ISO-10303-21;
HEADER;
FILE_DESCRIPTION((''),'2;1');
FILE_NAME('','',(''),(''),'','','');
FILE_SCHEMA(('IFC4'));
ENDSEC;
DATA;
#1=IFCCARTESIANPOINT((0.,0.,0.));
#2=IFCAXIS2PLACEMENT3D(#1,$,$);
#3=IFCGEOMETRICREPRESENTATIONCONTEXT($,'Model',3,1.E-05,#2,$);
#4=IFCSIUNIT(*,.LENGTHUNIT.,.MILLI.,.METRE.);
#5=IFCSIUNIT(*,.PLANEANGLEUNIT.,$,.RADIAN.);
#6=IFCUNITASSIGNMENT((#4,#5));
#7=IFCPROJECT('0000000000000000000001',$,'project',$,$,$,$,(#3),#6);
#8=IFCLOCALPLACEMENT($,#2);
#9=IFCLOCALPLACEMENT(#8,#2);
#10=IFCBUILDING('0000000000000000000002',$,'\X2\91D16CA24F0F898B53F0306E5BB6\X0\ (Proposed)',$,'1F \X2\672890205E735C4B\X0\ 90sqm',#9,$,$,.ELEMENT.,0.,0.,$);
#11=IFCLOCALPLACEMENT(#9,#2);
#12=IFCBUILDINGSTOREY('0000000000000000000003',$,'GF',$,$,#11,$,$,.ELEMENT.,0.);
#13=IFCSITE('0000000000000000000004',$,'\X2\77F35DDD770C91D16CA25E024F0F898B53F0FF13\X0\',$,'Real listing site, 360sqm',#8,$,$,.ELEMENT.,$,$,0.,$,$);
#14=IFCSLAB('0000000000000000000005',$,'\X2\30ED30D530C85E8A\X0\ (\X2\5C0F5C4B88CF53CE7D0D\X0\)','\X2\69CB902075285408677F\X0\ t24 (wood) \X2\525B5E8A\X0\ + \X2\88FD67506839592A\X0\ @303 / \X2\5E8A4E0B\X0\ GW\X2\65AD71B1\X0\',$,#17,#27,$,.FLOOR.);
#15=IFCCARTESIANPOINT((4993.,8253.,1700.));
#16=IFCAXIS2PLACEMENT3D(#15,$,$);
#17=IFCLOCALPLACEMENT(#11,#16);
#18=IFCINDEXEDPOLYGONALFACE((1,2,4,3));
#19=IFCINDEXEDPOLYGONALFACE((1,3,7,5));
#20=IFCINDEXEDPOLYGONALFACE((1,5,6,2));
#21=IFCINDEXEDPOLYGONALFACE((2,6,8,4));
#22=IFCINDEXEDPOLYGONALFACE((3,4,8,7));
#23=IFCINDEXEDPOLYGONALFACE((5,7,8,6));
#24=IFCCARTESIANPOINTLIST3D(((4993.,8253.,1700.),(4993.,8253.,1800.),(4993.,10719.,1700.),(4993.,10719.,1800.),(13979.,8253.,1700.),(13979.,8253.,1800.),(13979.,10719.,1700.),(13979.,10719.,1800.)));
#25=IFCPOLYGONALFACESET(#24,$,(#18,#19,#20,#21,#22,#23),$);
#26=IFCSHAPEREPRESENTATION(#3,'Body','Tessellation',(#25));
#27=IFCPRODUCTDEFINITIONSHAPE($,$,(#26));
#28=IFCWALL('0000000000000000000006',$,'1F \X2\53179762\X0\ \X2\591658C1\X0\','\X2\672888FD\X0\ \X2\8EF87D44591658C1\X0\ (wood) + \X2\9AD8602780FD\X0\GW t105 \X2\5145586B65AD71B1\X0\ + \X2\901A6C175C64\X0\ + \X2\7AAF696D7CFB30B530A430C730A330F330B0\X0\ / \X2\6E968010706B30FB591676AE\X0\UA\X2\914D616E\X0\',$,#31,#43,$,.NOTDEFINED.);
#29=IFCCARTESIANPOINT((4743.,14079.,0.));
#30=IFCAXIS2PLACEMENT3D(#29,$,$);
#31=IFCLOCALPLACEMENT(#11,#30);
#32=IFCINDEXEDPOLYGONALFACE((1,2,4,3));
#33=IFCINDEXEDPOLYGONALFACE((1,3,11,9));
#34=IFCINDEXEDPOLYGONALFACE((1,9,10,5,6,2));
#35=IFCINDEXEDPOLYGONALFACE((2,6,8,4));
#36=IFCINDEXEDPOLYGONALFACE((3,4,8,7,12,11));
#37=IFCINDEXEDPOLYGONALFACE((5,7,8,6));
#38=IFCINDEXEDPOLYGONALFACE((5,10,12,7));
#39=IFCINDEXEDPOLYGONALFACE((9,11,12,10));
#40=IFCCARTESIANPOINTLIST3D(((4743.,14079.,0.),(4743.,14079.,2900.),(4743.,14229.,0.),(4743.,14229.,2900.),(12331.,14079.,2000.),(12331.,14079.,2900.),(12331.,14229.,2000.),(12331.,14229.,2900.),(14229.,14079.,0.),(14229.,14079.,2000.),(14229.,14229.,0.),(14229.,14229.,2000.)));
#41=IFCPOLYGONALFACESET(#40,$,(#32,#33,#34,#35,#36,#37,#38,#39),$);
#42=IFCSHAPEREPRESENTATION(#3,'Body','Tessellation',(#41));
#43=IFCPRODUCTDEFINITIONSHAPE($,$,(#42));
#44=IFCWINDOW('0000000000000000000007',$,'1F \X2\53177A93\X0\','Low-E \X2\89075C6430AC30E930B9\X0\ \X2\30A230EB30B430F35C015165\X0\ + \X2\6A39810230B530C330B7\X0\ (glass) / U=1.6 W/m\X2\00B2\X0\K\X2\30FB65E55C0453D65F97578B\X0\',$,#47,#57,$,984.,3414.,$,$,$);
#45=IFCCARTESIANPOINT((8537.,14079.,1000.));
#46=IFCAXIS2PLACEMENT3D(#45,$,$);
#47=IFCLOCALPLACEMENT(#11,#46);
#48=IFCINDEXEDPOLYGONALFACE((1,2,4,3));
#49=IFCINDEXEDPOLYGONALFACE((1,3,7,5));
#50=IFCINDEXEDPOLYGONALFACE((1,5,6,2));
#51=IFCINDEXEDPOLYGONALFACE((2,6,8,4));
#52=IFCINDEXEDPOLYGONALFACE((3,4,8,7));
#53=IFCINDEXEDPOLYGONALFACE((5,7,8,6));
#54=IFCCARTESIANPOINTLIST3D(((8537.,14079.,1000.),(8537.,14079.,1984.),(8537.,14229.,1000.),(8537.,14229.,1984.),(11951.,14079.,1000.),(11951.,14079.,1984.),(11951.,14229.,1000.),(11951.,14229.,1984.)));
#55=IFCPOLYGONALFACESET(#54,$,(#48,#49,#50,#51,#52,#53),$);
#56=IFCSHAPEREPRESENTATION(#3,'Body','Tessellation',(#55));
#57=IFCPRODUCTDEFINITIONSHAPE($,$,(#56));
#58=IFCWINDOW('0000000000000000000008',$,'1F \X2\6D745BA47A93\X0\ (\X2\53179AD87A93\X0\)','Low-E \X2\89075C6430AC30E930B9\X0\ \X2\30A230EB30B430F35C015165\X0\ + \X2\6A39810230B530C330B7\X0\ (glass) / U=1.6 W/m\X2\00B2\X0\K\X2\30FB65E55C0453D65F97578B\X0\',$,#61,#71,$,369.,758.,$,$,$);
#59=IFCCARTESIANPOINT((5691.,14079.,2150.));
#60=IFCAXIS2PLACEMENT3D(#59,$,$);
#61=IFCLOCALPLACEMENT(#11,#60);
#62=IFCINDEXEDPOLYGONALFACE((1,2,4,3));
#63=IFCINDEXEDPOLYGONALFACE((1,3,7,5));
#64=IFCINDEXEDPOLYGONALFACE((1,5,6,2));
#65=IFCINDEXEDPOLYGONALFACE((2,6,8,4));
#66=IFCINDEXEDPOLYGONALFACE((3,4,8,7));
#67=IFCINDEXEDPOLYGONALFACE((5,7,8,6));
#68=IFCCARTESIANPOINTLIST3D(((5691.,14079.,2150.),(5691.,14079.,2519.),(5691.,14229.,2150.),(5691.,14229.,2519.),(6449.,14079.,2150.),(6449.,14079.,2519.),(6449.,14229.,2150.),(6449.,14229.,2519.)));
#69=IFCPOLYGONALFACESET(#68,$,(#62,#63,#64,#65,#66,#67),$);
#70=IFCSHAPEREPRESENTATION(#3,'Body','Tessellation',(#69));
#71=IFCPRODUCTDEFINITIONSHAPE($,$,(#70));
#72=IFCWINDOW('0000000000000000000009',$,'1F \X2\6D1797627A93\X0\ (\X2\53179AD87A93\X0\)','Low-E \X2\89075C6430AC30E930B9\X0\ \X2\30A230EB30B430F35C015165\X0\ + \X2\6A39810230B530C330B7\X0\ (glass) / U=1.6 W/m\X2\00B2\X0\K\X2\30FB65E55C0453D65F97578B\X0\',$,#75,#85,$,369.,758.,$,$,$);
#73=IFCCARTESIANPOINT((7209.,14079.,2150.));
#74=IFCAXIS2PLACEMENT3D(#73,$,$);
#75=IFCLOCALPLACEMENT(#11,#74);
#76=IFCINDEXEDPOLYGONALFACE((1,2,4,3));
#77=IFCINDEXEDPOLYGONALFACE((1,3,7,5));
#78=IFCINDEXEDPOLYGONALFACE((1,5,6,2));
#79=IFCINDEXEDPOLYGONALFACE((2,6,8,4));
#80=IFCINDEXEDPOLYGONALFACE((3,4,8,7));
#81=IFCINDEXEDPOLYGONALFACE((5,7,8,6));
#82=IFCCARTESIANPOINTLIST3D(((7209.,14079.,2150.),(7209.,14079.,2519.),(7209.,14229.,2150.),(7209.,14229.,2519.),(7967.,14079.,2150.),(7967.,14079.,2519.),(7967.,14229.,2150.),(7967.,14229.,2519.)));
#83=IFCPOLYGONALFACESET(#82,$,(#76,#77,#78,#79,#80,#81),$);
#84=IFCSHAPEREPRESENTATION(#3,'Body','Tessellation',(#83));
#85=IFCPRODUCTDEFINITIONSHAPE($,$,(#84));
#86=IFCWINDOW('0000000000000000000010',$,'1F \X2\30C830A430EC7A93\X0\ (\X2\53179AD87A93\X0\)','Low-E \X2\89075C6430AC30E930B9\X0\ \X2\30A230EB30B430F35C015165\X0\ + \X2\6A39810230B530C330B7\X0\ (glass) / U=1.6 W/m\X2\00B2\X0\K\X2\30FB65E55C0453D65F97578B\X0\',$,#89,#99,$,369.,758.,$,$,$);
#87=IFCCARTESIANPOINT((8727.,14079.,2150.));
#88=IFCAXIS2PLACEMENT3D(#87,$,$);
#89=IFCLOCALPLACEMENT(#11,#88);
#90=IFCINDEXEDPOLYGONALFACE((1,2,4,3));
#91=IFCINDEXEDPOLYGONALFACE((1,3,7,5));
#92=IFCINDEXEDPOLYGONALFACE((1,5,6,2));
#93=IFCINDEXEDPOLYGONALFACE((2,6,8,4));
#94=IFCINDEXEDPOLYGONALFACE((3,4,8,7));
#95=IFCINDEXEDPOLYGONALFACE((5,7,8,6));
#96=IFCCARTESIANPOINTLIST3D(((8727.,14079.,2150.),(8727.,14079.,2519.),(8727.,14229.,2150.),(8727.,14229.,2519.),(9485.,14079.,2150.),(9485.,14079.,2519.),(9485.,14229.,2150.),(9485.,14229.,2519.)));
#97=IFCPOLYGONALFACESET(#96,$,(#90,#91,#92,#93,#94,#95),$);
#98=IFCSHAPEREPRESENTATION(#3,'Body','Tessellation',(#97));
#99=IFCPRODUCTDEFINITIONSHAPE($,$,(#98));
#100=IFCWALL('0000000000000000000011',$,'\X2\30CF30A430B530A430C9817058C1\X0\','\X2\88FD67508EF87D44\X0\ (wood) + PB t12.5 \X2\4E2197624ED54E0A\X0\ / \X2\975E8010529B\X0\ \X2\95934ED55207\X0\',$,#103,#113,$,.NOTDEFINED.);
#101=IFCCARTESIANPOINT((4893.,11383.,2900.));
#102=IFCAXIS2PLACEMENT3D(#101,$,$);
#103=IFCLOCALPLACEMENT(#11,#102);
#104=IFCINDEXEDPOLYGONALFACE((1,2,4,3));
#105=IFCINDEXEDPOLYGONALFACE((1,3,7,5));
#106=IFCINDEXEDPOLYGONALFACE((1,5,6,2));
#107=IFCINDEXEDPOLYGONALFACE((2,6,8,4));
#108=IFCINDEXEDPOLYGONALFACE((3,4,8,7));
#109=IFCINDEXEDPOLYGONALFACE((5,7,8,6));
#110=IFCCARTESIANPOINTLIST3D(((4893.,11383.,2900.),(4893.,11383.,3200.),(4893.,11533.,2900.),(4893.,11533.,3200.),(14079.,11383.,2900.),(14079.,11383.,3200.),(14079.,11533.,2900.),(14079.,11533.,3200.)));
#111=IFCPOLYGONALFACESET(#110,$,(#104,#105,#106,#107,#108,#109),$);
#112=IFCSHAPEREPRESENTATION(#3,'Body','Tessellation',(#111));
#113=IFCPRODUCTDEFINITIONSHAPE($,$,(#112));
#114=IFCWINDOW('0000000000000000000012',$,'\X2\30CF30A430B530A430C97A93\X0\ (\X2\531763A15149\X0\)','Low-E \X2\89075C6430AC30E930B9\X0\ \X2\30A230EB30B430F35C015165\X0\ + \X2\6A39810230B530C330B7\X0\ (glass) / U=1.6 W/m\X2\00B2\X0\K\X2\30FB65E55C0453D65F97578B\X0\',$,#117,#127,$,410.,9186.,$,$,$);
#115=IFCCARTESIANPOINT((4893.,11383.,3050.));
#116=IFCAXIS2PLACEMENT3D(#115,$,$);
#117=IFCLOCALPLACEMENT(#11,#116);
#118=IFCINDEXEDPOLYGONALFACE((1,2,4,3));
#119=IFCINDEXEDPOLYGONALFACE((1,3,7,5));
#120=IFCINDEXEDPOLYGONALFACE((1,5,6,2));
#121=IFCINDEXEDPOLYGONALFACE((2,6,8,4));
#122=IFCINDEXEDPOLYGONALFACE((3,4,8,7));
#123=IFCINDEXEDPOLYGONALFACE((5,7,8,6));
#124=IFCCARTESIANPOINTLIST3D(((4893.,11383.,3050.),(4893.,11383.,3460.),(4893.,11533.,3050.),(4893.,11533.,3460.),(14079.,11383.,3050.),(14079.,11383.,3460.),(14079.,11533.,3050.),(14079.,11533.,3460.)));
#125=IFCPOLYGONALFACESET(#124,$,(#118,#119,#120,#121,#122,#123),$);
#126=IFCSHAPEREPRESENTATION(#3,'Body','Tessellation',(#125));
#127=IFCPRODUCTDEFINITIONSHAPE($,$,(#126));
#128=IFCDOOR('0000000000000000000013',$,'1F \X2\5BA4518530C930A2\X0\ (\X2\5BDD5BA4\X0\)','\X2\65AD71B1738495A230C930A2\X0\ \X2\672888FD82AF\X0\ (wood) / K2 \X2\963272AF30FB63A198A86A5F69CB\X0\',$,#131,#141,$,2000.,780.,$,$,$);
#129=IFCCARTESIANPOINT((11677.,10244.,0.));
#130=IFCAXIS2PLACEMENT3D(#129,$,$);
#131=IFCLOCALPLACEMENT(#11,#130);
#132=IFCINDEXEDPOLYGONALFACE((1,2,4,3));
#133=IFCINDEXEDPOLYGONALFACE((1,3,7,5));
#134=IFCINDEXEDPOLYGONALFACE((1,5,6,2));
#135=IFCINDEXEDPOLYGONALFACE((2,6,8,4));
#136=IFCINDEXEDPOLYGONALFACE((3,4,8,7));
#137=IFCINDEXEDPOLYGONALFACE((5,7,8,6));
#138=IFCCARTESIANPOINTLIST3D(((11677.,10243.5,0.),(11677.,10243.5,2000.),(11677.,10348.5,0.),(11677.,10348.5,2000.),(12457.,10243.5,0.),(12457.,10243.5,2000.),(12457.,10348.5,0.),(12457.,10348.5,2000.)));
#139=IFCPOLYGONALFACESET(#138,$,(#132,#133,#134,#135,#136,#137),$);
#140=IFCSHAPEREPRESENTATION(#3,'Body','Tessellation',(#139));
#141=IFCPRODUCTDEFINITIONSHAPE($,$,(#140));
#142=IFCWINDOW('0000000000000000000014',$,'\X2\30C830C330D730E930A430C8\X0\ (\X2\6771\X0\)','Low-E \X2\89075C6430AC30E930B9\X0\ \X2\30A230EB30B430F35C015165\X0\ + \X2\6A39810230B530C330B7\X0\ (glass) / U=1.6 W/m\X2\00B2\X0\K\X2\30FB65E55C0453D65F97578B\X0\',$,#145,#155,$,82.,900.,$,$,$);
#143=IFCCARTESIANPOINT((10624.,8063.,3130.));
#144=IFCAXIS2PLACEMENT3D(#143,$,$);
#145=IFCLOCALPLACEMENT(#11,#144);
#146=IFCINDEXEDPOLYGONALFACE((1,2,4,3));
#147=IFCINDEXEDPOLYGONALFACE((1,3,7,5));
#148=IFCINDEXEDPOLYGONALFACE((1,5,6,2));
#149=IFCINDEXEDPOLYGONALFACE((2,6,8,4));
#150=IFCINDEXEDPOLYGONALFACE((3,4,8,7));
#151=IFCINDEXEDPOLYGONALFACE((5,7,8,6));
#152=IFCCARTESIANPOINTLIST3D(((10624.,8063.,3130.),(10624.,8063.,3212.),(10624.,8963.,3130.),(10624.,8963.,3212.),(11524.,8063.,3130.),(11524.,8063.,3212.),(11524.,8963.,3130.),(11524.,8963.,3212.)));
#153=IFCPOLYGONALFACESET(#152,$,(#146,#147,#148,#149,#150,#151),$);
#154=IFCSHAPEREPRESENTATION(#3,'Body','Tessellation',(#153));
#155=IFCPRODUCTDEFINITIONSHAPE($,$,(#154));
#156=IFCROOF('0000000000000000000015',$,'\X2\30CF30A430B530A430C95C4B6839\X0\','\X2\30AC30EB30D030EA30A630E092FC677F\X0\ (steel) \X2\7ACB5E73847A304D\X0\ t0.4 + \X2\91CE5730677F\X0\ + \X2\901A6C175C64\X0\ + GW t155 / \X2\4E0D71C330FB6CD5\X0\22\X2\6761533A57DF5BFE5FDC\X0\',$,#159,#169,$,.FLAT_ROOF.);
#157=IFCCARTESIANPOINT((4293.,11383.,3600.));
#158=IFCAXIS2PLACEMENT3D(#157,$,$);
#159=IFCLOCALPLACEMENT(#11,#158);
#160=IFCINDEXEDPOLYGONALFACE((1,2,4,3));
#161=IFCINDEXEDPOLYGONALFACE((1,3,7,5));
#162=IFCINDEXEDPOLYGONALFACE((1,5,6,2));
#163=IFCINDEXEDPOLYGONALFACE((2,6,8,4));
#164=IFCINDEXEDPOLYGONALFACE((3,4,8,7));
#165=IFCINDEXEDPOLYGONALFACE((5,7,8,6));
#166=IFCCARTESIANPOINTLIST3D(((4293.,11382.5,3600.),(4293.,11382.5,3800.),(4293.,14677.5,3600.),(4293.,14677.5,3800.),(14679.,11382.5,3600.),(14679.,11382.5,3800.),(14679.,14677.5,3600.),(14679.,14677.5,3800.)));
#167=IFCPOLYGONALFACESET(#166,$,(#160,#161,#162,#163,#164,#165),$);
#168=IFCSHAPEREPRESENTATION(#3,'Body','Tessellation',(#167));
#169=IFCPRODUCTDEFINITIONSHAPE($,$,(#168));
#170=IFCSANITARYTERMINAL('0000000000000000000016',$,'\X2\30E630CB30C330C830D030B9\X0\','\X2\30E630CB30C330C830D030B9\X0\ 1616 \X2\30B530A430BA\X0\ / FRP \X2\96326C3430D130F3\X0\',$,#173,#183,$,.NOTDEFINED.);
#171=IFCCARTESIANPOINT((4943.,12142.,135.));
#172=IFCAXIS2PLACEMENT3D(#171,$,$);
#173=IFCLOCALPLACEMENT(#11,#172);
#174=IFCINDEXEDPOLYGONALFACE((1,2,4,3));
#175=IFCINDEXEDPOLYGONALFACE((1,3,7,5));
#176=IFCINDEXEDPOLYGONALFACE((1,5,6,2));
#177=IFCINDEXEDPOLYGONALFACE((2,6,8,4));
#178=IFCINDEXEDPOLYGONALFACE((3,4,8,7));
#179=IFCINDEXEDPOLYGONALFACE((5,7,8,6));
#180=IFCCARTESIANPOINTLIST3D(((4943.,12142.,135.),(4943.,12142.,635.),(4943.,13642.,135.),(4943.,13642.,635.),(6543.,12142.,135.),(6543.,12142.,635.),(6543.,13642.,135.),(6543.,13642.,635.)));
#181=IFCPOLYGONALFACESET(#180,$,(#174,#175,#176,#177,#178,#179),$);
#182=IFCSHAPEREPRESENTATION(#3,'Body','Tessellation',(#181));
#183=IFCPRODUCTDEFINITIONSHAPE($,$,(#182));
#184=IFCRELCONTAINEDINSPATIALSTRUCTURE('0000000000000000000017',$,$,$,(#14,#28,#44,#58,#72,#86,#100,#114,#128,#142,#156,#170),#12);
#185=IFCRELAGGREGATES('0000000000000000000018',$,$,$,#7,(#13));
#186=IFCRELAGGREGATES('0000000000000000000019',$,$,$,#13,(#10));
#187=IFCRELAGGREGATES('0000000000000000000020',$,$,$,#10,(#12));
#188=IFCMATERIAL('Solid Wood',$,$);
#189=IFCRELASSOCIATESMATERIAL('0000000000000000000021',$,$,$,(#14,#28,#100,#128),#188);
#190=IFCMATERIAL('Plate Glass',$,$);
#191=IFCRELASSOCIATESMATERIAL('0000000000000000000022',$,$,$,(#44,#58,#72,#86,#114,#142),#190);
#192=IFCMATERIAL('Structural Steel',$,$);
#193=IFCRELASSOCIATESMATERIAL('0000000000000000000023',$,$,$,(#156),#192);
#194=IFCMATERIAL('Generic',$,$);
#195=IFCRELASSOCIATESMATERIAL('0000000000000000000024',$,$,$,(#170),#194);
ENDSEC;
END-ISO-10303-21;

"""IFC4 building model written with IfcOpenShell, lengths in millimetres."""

from ifc_helpers import new_model, si_unit, frame, frame_2d, origin, place, context, project, spatial, rectangle, extrude, material, element, fill, save


model = new_model("IFC4")

# Units and contexts
model_context = context("Model", 3, precision=1e-05, world=origin())
ifc_project = project(units=[si_unit("LENGTHUNIT", "METRE", prefix="MILLI"), si_unit("PLANEANGLEUNIT", "RADIAN")], contexts=[model_context])

# Site, building, storey
site_placement = place(None, origin())
site = spatial("IfcSite", under=ifc_project, at=site_placement, Name="石川県金沢市伏見台３", ObjectType="Real listing site, 360sqm", CompositionType="ELEMENT", RefElevation=0.0)
building_placement = place(site_placement, origin())
building = spatial("IfcBuilding", under=site, at=building_placement, Name="金沢伏見台の家 (Proposed)", ObjectType="1F 木造平屋 90sqm", CompositionType="ELEMENT", ElevationOfRefHeight=0.0, ElevationOfTerrain=0.0)
storey_placement = place(building_placement, origin())
storey = spatial("IfcBuildingStorey", under=building, at=storey_placement, Name="GF", CompositionType="ELEMENT", Elevation=0.0)

# Slab
ifc_material_1 = material(Name="Solid Wood")
slab_placement = place(storey_placement, frame((4993.0, 8253.0, 1700.0)))
element("IfcSlab", 1, at=slab_placement, inside=storey, material=ifc_material_1, Name="ロフト床 (小屋裏収納)", Description="構造用合板 t24 (wood) 剛床 + 製材根太 @303 / 床下 GW断熱", PredefinedType="FLOOR", context=model_context, shape_type="SweptSolid", body=[
    extrude(rectangle(XDim=8986.0, YDim=2466.0, at=frame_2d((4493.0, 1233.0))), frame((4993.0, 8253.0, 1700.0)), (0.0, 0.0, 1.0), 100.0),
])

# Wall, openings, windows
wall_1_placement = place(storey_placement, frame((4743.0, 14079.0, 0.0)))
wall_1 = element("IfcWall", 2, at=wall_1_placement, inside=storey, material=ifc_material_1, Name="1F 北面 外壁", Description="木製 軸組外壁 (wood) + 高性能GW t105 充填断熱 + 通気層 + 窯業系サイディング / 準耐火・外皮UA配慮", PredefinedType="NOTDEFINED", context=model_context, shape_type="SweptSolid", body=[
    extrude(rectangle(XDim=9486.0, YDim=150.0, at=frame_2d((4743.0, 75.0))), frame((4743.0, 14079.0, 0.0)), (0.0, 0.0, 1.0), 2900.0),
])
opening_1_placement = place(storey_placement, frame((8537.0, 14079.0, 1000.0)))
opening_1 = element("IfcOpeningElement", 3, at=opening_1_placement, cuts=wall_1, PredefinedType="NOTDEFINED", context=model_context, shape_type="SweptSolid", body=[
    extrude(rectangle(XDim=3414.0, YDim=150.0, at=frame_2d((1707.0, 75.0))), frame((8537.0, 14079.0, 1000.0)), (0.0, 0.0, 1.0), 984.0),
])
opening_2_placement = place(storey_placement, frame((5691.0, 14079.0, 2150.0)))
opening_2 = element("IfcOpeningElement", 4, at=opening_2_placement, cuts=wall_1, PredefinedType="NOTDEFINED", context=model_context, shape_type="SweptSolid", body=[
    extrude(rectangle(XDim=758.0, YDim=150.0, at=frame_2d((379.0, 75.0))), frame((5691.0, 14079.0, 2150.0)), (0.0, 0.0, 1.0), 369.0),
])
opening_3_placement = place(storey_placement, frame((7209.0, 14079.0, 2150.0)))
opening_3 = element("IfcOpeningElement", 5, at=opening_3_placement, cuts=wall_1, PredefinedType="NOTDEFINED", context=model_context, shape_type="SweptSolid", body=[
    extrude(rectangle(XDim=758.0, YDim=150.0, at=frame_2d((379.0, 75.0))), frame((7209.0, 14079.0, 2150.0)), (0.0, 0.0, 1.0), 369.0),
])
opening_4_placement = place(storey_placement, frame((8727.0, 14079.0, 2150.0)))
opening_4 = element("IfcOpeningElement", 6, at=opening_4_placement, cuts=wall_1, PredefinedType="NOTDEFINED", context=model_context, shape_type="SweptSolid", body=[
    extrude(rectangle(XDim=758.0, YDim=150.0, at=frame_2d((379.0, 75.0))), frame((8727.0, 14079.0, 2150.0)), (0.0, 0.0, 1.0), 369.0),
])
ifc_material_2 = material(Name="Plate Glass")
window_1_placement = place(storey_placement, frame((8537.0, 14079.0, 1000.0)))
window_1 = element("IfcWindow", 7, at=window_1_placement, inside=storey, material=ifc_material_2, Name="1F 北窓", Description="Low-E 複層ガラス アルゴン封入 + 樹脂サッシ (glass) / U=1.6 W/m²K・日射取得型", OverallHeight=984.0, OverallWidth=3414.0, context=model_context, shape_type="SweptSolid", body=[
    extrude(rectangle(XDim=3414.0, YDim=150.0, at=frame_2d((1707.0, 75.0))), frame((8537.0, 14079.0, 1000.0)), (0.0, 0.0, 1.0), 984.0),
])
fill(opening_1, window_1)
window_2_placement = place(storey_placement, frame((5691.0, 14079.0, 2150.0)))
window_2 = element("IfcWindow", 8, at=window_2_placement, inside=storey, material=ifc_material_2, Name="1F 浴室窓 (北高窓)", Description="Low-E 複層ガラス アルゴン封入 + 樹脂サッシ (glass) / U=1.6 W/m²K・日射取得型", OverallHeight=369.0, OverallWidth=758.0, context=model_context, shape_type="SweptSolid", body=[
    extrude(rectangle(XDim=758.0, YDim=150.0, at=frame_2d((379.0, 75.0))), frame((5691.0, 14079.0, 2150.0)), (0.0, 0.0, 1.0), 369.0),
])
fill(opening_2, window_2)
window_3_placement = place(storey_placement, frame((7209.0, 14079.0, 2150.0)))
window_3 = element("IfcWindow", 9, at=window_3_placement, inside=storey, material=ifc_material_2, Name="1F 洗面窓 (北高窓)", Description="Low-E 複層ガラス アルゴン封入 + 樹脂サッシ (glass) / U=1.6 W/m²K・日射取得型", OverallHeight=369.0, OverallWidth=758.0, context=model_context, shape_type="SweptSolid", body=[
    extrude(rectangle(XDim=758.0, YDim=150.0, at=frame_2d((379.0, 75.0))), frame((7209.0, 14079.0, 2150.0)), (0.0, 0.0, 1.0), 369.0),
])
fill(opening_3, window_3)
window_4_placement = place(storey_placement, frame((8727.0, 14079.0, 2150.0)))
window_4 = element("IfcWindow", 10, at=window_4_placement, inside=storey, material=ifc_material_2, Name="1F トイレ窓 (北高窓)", Description="Low-E 複層ガラス アルゴン封入 + 樹脂サッシ (glass) / U=1.6 W/m²K・日射取得型", OverallHeight=369.0, OverallWidth=758.0, context=model_context, shape_type="SweptSolid", body=[
    extrude(rectangle(XDim=758.0, YDim=150.0, at=frame_2d((379.0, 75.0))), frame((8727.0, 14079.0, 2150.0)), (0.0, 0.0, 1.0), 369.0),
])
fill(opening_4, window_4)

# Wall, opening, window
wall_2_placement = place(storey_placement, frame((4893.0, 11383.0, 2900.0)))
wall_2 = element("IfcWall", 11, at=wall_2_placement, inside=storey, material=ifc_material_1, Name="ハイサイド腰壁", Description="製材軸組 (wood) + PB t12.5 両面仕上 / 非耐力 間仕切", PredefinedType="NOTDEFINED", context=model_context, shape_type="SweptSolid", body=[
    extrude(rectangle(XDim=9186.0, YDim=150.0, at=frame_2d((4593.0, 75.0))), frame((4893.0, 11383.0, 2900.0)), (0.0, 0.0, 1.0), 700.0),
])
opening_5_placement = place(storey_placement, frame((4893.0, 11383.0, 3050.0)))
opening_5 = element("IfcOpeningElement", 12, at=opening_5_placement, cuts=wall_2, PredefinedType="NOTDEFINED", context=model_context, shape_type="SweptSolid", body=[
    extrude(rectangle(XDim=9186.0, YDim=150.0, at=frame_2d((4593.0, 75.0))), frame((4893.0, 11383.0, 3050.0)), (0.0, 0.0, 1.0), 410.0),
])
window_5_placement = place(storey_placement, frame((4893.0, 11383.0, 3050.0)))
window_5 = element("IfcWindow", 13, at=window_5_placement, inside=storey, material=ifc_material_2, Name="ハイサイド窓 (北採光)", Description="Low-E 複層ガラス アルゴン封入 + 樹脂サッシ (glass) / U=1.6 W/m²K・日射取得型", OverallHeight=410.0, OverallWidth=9186.0, context=model_context, shape_type="SweptSolid", body=[
    extrude(rectangle(XDim=9186.0, YDim=150.0, at=frame_2d((4593.0, 75.0))), frame((4893.0, 11383.0, 3050.0)), (0.0, 0.0, 1.0), 410.0),
])
fill(opening_5, window_5)

# Door
door_1_placement = place(storey_placement, frame((11677.0, 10244.0, 0.0)))
element("IfcDoor", 14, at=door_1_placement, inside=storey, material=ifc_material_1, Name="1F 室内ドア (寝室)", Description="断熱玄関ドア 木製芯 (wood) / K2 防犯・採風機構", OverallHeight=2000.0, OverallWidth=780.0, context=model_context, shape_type="SweptSolid", body=[
    extrude(rectangle(XDim=780.0, YDim=105.0, at=frame_2d((390.0, 52.0))), frame((11677.0, 10244.0, 0.0)), (0.0, 0.0, 1.0), 2000.0),
])

# Window
window_6_placement = place(storey_placement, frame((10624.0, 8063.0, 3130.0)))
element("IfcWindow", 15, at=window_6_placement, inside=storey, material=ifc_material_2, Name="トップライト (東)", Description="Low-E 複層ガラス アルゴン封入 + 樹脂サッシ (glass) / U=1.6 W/m²K・日射取得型", OverallHeight=82.0, OverallWidth=900.0, context=model_context, shape_type="SweptSolid", body=[
    extrude(rectangle(XDim=900.0, YDim=900.0, at=frame_2d((450.0, 450.0))), frame((10624.0, 8063.0, 3130.0)), (0.0, 0.0, 1.0), 82.0),
])

# Roof
ifc_material_3 = material(Name="Structural Steel")
roof_placement = place(storey_placement, frame((4293.0, 11383.0, 3600.0)))
element("IfcRoof", 16, at=roof_placement, inside=storey, material=ifc_material_3, Name="ハイサイド屋根", Description="ガルバリウム鋼板 (steel) 立平葺き t0.4 + 野地板 + 通気層 + GW t155 / 不燃・法22条区域対応", PredefinedType="FLAT_ROOF", context=model_context, shape_type="SweptSolid", body=[
    extrude(rectangle(XDim=10386.0, YDim=3295.0, at=frame_2d((5193.0, 1647.0))), frame((4293.0, 11383.0, 3600.0)), (0.0, 0.0, 1.0), 200.0),
])

# Sanitary terminal
ifc_material_4 = material(Name="Generic")
sanitary_terminal_1_placement = place(storey_placement, frame((4943.0, 12142.0, 135.0)))
element("IfcSanitaryTerminal", 17, at=sanitary_terminal_1_placement, inside=storey, material=ifc_material_4, Name="ユニットバス", Description="ユニットバス 1616 サイズ / FRP 防水パン", PredefinedType="NOTDEFINED", context=model_context, shape_type="SweptSolid", body=[
    extrude(rectangle(XDim=1600.0, YDim=1500.0, at=frame_2d((800.0, 750.0))), frame((4943.0, 12142.0, 135.0)), (0.0, 0.0, 1.0), 500.0),
])

save(model, "model.ifc")
